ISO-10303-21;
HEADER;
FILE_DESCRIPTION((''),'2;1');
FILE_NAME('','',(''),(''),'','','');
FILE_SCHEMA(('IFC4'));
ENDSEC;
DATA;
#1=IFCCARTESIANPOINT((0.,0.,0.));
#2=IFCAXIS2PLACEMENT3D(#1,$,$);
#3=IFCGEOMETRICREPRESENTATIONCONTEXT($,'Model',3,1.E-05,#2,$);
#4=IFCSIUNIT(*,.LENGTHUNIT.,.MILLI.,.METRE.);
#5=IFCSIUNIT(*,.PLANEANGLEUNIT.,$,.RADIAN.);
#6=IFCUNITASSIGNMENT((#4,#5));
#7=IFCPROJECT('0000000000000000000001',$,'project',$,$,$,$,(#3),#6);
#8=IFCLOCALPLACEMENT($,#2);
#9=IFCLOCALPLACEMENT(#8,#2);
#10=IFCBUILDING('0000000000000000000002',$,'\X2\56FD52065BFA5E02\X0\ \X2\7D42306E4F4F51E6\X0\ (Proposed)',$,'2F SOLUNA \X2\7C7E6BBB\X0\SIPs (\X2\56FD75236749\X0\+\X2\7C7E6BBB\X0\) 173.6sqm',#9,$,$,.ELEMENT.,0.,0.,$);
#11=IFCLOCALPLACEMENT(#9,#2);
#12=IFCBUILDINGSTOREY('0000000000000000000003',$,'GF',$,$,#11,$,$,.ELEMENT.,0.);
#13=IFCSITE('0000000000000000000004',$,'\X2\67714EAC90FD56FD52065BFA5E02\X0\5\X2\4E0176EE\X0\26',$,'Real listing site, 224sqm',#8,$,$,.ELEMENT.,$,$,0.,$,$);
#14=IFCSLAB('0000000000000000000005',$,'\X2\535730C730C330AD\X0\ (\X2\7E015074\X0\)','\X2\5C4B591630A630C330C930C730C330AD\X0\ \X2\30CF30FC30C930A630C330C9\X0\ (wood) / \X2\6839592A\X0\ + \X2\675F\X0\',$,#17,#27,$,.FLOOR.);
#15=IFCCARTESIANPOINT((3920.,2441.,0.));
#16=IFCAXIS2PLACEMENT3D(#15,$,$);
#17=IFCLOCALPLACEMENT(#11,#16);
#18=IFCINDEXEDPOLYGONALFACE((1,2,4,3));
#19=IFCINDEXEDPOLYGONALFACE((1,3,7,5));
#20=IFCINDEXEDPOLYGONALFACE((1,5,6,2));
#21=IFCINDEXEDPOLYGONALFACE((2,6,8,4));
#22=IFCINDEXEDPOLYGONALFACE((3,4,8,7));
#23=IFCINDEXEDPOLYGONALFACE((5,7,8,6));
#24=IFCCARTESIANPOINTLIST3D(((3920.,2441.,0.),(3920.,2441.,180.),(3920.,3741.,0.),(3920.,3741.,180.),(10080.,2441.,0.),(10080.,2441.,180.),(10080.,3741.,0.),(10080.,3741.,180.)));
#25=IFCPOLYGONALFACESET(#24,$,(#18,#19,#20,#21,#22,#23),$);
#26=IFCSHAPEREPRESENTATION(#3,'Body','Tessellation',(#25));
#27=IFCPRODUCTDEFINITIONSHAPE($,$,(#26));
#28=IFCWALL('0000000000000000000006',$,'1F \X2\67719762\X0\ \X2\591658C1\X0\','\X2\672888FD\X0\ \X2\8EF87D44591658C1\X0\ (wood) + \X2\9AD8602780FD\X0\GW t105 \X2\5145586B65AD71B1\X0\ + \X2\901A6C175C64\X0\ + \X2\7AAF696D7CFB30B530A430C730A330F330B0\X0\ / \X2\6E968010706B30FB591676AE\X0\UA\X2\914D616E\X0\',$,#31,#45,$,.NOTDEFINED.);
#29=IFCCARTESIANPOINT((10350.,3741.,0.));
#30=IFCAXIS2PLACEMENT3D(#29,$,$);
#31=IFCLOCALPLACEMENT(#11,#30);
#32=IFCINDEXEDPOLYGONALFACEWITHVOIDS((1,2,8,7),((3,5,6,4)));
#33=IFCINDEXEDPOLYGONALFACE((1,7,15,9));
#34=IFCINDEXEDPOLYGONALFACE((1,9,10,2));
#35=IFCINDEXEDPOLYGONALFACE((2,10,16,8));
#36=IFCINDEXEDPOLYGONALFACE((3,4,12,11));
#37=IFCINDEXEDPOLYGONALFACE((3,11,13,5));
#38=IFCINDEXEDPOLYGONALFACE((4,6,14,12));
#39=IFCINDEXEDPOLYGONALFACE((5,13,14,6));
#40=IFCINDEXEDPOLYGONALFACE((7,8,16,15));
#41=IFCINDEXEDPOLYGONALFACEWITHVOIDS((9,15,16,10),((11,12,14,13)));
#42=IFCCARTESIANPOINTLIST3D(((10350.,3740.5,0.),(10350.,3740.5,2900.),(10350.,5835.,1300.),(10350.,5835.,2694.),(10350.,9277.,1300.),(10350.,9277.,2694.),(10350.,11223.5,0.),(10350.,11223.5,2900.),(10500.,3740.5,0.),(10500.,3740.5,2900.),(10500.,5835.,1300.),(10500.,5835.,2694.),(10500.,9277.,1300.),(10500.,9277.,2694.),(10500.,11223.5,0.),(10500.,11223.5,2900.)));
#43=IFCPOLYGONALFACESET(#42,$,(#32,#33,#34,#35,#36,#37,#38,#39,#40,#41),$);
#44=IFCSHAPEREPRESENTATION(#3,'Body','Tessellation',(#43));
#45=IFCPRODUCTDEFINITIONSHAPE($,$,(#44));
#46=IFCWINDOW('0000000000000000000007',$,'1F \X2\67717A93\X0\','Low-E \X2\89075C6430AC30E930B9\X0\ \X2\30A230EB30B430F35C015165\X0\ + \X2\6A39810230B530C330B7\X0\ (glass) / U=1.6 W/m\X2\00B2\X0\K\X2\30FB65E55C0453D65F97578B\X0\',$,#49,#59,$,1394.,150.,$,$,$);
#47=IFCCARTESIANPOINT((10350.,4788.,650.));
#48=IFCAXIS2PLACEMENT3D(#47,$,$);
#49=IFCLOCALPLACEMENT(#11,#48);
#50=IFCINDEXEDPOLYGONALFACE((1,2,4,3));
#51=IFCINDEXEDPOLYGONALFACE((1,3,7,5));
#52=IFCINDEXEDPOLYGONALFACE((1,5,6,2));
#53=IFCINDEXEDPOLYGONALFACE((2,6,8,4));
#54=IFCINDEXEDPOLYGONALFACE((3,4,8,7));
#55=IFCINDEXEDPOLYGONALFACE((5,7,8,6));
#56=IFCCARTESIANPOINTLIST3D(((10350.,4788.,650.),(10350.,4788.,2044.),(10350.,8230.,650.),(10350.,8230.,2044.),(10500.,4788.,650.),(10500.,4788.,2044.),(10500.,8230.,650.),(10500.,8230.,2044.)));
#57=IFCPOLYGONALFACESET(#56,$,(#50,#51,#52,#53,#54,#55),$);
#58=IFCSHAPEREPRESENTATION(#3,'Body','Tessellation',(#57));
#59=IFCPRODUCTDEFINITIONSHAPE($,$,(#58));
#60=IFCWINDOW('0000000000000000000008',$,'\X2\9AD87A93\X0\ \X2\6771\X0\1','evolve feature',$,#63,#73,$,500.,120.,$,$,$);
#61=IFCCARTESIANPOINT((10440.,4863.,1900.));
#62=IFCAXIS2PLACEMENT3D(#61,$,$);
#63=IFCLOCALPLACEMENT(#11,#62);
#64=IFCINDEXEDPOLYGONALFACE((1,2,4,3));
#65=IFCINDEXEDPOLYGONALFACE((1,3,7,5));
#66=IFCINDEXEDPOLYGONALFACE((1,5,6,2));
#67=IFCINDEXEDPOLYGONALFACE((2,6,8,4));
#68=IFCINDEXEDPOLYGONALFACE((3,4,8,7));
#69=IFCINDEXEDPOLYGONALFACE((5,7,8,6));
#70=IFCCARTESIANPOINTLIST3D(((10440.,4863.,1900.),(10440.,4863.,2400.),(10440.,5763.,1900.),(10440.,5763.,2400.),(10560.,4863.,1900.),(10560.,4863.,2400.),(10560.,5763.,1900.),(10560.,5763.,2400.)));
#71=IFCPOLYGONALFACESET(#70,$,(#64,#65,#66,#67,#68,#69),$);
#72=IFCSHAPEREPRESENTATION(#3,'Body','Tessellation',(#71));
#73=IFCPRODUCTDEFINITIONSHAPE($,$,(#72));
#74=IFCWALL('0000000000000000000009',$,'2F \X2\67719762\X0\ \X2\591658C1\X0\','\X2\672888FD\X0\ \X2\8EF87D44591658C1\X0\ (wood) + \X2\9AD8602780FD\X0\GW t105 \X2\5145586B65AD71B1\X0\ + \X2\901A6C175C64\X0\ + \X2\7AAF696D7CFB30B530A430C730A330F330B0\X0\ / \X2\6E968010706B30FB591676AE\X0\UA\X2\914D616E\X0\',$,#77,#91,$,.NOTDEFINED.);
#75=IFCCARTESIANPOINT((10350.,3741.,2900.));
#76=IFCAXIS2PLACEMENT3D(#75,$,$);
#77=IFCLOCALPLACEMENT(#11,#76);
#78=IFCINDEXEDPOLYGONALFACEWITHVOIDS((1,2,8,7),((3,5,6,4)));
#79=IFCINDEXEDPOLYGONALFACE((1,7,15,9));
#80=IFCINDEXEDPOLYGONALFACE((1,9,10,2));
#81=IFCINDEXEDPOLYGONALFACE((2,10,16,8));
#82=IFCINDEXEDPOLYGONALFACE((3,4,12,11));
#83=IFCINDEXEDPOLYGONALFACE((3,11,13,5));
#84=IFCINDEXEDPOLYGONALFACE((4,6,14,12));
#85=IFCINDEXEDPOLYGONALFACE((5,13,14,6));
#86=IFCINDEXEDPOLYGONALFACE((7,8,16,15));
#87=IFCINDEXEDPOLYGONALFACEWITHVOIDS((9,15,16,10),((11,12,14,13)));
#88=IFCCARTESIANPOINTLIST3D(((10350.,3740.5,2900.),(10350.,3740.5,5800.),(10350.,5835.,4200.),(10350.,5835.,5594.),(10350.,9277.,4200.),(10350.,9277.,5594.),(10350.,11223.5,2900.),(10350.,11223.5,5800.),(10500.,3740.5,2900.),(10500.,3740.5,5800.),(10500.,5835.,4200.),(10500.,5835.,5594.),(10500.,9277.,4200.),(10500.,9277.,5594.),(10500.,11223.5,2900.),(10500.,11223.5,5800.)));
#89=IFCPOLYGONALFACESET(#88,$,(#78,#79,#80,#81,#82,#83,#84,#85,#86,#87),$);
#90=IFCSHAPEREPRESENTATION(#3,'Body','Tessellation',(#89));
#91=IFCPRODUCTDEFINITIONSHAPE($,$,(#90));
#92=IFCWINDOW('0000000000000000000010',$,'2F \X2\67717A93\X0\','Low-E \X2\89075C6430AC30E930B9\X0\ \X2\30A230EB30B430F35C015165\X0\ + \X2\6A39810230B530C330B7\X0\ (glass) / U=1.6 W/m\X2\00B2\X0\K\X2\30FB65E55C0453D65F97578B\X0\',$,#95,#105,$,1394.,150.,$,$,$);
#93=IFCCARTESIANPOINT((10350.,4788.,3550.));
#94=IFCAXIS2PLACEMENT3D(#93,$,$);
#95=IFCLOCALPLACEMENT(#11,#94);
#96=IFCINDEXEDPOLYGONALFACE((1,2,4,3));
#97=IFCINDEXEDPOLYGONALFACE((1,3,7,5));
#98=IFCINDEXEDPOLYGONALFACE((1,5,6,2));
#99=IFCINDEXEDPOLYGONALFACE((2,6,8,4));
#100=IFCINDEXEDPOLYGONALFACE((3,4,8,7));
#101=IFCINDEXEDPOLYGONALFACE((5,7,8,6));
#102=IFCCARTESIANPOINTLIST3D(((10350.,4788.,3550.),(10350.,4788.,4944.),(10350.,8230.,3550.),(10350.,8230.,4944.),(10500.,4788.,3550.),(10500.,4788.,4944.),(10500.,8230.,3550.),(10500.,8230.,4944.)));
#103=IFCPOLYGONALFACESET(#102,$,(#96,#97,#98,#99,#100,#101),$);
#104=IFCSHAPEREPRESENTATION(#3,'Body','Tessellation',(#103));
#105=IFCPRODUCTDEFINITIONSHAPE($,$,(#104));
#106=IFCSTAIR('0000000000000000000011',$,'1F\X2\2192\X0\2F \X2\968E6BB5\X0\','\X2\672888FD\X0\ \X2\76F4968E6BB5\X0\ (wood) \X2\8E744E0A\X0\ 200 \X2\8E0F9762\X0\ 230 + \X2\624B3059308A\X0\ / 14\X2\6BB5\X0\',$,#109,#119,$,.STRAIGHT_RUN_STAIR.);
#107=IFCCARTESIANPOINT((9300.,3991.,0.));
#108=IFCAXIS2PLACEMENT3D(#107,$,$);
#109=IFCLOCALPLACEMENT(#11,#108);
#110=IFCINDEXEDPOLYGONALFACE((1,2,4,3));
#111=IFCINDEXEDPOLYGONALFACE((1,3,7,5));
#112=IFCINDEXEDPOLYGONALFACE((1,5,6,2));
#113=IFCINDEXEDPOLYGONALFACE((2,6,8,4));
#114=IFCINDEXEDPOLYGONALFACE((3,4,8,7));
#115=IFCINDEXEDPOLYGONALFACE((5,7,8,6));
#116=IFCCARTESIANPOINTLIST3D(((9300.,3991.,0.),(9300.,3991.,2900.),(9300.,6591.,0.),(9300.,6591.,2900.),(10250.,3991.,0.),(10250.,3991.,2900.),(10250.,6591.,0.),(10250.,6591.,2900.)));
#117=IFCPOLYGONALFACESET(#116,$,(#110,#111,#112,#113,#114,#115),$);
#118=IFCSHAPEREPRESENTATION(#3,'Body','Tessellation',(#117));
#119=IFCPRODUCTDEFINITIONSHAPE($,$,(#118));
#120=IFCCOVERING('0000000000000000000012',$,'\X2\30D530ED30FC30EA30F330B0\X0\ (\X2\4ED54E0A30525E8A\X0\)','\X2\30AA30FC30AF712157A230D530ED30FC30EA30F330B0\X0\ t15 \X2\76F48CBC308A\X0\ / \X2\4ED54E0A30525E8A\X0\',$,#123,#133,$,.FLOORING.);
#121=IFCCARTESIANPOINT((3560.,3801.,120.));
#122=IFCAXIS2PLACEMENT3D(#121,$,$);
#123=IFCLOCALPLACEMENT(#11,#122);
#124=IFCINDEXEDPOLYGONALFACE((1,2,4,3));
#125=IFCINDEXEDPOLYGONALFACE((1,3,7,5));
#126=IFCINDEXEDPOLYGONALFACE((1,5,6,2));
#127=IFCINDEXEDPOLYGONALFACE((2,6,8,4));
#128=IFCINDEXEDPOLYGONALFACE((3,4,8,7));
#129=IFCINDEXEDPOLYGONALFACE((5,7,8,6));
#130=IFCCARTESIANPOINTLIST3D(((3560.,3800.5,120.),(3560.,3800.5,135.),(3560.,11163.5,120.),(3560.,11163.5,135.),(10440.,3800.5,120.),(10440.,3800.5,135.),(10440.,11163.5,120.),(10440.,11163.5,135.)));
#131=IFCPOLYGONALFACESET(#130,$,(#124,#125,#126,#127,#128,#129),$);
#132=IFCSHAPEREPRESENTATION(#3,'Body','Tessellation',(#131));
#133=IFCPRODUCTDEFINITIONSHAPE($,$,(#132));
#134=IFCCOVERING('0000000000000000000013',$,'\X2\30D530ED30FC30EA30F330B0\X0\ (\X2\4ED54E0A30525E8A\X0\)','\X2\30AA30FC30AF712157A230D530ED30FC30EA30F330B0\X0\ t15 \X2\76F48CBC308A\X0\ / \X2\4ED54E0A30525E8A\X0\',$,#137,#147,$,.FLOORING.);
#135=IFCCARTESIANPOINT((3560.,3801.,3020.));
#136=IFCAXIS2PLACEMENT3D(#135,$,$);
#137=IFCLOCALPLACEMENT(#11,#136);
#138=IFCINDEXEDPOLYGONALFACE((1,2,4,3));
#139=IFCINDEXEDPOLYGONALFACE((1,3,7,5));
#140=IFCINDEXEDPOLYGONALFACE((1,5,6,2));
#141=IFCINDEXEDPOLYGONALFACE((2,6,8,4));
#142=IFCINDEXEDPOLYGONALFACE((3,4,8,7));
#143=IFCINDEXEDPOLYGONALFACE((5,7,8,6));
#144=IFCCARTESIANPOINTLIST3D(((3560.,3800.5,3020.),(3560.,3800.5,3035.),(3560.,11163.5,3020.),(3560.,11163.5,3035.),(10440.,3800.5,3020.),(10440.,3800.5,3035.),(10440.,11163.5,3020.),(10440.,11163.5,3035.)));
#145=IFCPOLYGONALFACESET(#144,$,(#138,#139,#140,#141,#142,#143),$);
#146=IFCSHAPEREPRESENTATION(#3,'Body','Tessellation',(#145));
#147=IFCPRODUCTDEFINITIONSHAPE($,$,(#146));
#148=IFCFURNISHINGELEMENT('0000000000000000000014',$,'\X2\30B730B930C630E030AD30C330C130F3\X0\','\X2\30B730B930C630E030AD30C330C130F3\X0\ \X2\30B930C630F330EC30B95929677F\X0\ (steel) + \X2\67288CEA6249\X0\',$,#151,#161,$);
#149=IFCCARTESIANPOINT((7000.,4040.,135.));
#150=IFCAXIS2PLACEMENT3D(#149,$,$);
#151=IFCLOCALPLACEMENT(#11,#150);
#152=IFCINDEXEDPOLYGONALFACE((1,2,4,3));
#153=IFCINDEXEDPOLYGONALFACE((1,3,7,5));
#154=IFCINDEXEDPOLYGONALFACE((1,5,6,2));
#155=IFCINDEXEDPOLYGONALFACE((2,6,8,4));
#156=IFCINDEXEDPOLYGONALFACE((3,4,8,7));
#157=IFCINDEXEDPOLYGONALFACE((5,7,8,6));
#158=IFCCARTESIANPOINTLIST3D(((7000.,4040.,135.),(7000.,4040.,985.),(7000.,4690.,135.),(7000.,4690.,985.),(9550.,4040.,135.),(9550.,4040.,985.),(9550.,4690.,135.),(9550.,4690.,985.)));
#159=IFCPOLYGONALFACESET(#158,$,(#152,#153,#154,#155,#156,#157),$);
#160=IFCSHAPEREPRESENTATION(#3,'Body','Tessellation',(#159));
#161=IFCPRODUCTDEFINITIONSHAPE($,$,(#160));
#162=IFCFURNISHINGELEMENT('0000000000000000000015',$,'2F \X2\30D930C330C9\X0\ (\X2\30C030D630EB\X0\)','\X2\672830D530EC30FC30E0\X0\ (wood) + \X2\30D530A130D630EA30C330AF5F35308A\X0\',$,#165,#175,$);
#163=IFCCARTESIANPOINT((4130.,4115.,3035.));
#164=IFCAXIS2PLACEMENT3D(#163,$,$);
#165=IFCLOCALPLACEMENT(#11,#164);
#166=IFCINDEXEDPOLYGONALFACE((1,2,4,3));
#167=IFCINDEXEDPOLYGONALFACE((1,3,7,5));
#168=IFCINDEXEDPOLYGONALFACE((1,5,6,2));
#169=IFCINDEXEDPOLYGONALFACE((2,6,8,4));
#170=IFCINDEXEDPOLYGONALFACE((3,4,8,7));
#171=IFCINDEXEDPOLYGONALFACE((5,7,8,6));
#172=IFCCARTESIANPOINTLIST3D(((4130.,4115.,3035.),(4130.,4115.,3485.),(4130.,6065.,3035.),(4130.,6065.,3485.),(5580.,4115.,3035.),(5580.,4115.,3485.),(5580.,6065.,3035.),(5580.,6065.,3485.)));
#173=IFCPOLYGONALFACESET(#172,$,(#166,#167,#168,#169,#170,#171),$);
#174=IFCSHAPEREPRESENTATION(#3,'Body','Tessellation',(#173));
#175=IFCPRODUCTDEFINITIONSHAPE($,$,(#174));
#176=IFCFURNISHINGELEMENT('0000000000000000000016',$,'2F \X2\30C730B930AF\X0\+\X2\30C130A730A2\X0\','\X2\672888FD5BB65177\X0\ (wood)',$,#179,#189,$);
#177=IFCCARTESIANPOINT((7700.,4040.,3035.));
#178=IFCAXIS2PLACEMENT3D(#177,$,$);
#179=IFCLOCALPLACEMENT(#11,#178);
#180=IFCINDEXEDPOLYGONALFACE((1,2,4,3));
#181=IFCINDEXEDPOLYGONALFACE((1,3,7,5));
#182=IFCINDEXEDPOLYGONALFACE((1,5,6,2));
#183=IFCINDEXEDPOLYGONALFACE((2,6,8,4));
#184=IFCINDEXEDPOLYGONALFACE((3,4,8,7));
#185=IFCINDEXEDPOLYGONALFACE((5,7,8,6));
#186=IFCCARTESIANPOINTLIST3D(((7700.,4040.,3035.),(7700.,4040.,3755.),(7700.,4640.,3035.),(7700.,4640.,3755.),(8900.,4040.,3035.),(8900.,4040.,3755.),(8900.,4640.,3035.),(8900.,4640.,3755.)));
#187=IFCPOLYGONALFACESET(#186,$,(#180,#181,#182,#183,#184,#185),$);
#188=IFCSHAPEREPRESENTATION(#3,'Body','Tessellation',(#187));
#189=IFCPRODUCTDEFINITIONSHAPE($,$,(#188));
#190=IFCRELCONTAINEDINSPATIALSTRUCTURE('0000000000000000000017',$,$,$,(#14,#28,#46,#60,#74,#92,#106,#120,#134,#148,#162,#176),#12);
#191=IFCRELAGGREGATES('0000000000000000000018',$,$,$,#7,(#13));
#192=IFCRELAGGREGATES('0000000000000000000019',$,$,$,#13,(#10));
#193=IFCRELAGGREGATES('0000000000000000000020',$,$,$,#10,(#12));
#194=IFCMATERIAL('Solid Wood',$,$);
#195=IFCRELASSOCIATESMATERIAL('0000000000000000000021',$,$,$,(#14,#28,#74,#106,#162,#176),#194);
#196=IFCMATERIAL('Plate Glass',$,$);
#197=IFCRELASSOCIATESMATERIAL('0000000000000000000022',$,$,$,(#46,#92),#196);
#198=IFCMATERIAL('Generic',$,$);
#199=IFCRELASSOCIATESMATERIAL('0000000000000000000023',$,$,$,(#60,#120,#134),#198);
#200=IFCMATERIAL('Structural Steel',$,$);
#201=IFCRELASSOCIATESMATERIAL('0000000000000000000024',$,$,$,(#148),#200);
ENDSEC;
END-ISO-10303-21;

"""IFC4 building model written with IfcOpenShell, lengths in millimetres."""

from ifc_helpers import new_model, si_unit, frame, frame_2d, origin, place, context, project, spatial, rectangle, extrude, material, element, fill, save


model = new_model("IFC4")

# Units and contexts
model_context = context("Model", 3, precision=1e-05, world=origin())
ifc_project = project(units=[si_unit("LENGTHUNIT", "METRE", prefix="MILLI"), si_unit("PLANEANGLEUNIT", "RADIAN")], contexts=[model_context])

# Site, building, storey
site_placement = place(None, origin())
site = spatial("IfcSite", under=ifc_project, at=site_placement, Name="東京都国分寺市5丁目26", ObjectType="Real listing site, 224sqm", CompositionType="ELEMENT", RefElevation=0.0)
building_placement = place(site_placement, origin())
building = spatial("IfcBuilding", under=site, at=building_placement, Name="国分寺市 終の住処 (Proposed)", ObjectType="2F SOLUNA 籾殻SIPs (国産杉+籾殻) 173.6sqm", CompositionType="ELEMENT", ElevationOfRefHeight=0.0, ElevationOfTerrain=0.0)
storey_placement = place(building_placement, origin())
storey = spatial("IfcBuildingStorey", under=building, at=storey_placement, Name="GF", CompositionType="ELEMENT", Elevation=0.0)

# Slab
ifc_material_1 = material(Name="Solid Wood")
slab_placement = place(storey_placement, frame((3920.0, 2441.0, 0.0)))
element("IfcSlab", 1, at=slab_placement, inside=storey, material=ifc_material_1, Name="南デッキ (縁側)", Description="屋外ウッドデッキ ハードウッド (wood) / 根太 + 束", PredefinedType="FLOOR", context=model_context, shape_type="SweptSolid", body=[
    extrude(rectangle(XDim=6160.0, YDim=1300.0, at=frame_2d((3080.0, 650.0))), frame((3920.0, 2441.0, 0.0)), (0.0, 0.0, 1.0), 180.0),
])

# Wall, openings, windows
wall_1_placement = place(storey_placement, frame((10350.0, 3741.0, 0.0)))
wall_1 = element("IfcWall", 2, at=wall_1_placement, inside=storey, material=ifc_material_1, Name="1F 東面 外壁", Description="木製 軸組外壁 (wood) + 高性能GW t105 充填断熱 + 通気層 + 窯業系サイディング / 準耐火・外皮UA配慮", PredefinedType="NOTDEFINED", context=model_context, shape_type="SweptSolid", body=[
    extrude(rectangle(XDim=150.0, YDim=7483.0, at=frame_2d((75.0, 3741.0))), frame((10350.0, 3741.0, 0.0)), (0.0, 0.0, 1.0), 2900.0),
])
opening_1_placement = place(storey_placement, frame((10350.0, 4788.0, 650.0)))
opening_1 = element("IfcOpeningElement", 3, at=opening_1_placement, cuts=wall_1, PredefinedType="NOTDEFINED", context=model_context, shape_type="SweptSolid", body=[
    extrude(rectangle(XDim=150.0, YDim=3442.0, at=frame_2d((75.0, 1721.0))), frame((10350.0, 4788.0, 650.0)), (0.0, 0.0, 1.0), 1394.0),
])
opening_2_placement = place(storey_placement, frame((10440.0, 4863.0, 1900.0)))
opening_2 = element("IfcOpeningElement", 4, at=opening_2_placement, cuts=wall_1, PredefinedType="NOTDEFINED", context=model_context, shape_type="SweptSolid", body=[
    extrude(rectangle(XDim=120.0, YDim=900.0, at=frame_2d((60.0, 450.0))), frame((10440.0, 4863.0, 1900.0)), (0.0, 0.0, 1.0), 500.0),
])
ifc_material_2 = material(Name="Plate Glass")
window_1_placement = place(storey_placement, frame((10350.0, 4788.0, 650.0)))
window_1 = element("IfcWindow", 5, at=window_1_placement, inside=storey, material=ifc_material_2, Name="1F 東窓", Description="Low-E 複層ガラス アルゴン封入 + 樹脂サッシ (glass) / U=1.6 W/m²K・日射取得型", OverallHeight=1394.0, OverallWidth=150.0, context=model_context, shape_type="SweptSolid", body=[
    extrude(rectangle(XDim=150.0, YDim=3442.0, at=frame_2d((75.0, 1721.0))), frame((10350.0, 4788.0, 650.0)), (0.0, 0.0, 1.0), 1394.0),
])
fill(opening_1, window_1)
ifc_material_3 = material(Name="Generic")
window_2_placement = place(storey_placement, frame((10440.0, 4863.0, 1900.0)))
window_2 = element("IfcWindow", 6, at=window_2_placement, inside=storey, material=ifc_material_3, Name="高窓 東1", Description="evolve feature", OverallHeight=500.0, OverallWidth=120.0, context=model_context, shape_type="SweptSolid", body=[
    extrude(rectangle(XDim=120.0, YDim=900.0, at=frame_2d((60.0, 450.0))), frame((10440.0, 4863.0, 1900.0)), (0.0, 0.0, 1.0), 500.0),
])
fill(opening_2, window_2)

# Wall, opening, window
wall_2_placement = place(storey_placement, frame((10350.0, 3741.0, 2900.0)))
wall_2 = element("IfcWall", 7, at=wall_2_placement, inside=storey, material=ifc_material_1, Name="2F 東面 外壁", Description="木製 軸組外壁 (wood) + 高性能GW t105 充填断熱 + 通気層 + 窯業系サイディング / 準耐火・外皮UA配慮", PredefinedType="NOTDEFINED", context=model_context, shape_type="SweptSolid", body=[
    extrude(rectangle(XDim=150.0, YDim=7483.0, at=frame_2d((75.0, 3741.0))), frame((10350.0, 3741.0, 2900.0)), (0.0, 0.0, 1.0), 2900.0),
])
opening_3_placement = place(storey_placement, frame((10350.0, 4788.0, 3550.0)))
opening_3 = element("IfcOpeningElement", 8, at=opening_3_placement, cuts=wall_2, PredefinedType="NOTDEFINED", context=model_context, shape_type="SweptSolid", body=[
    extrude(rectangle(XDim=150.0, YDim=3442.0, at=frame_2d((75.0, 1721.0))), frame((10350.0, 4788.0, 3550.0)), (0.0, 0.0, 1.0), 1394.0),
])
window_3_placement = place(storey_placement, frame((10350.0, 4788.0, 3550.0)))
window_3 = element("IfcWindow", 9, at=window_3_placement, inside=storey, material=ifc_material_2, Name="2F 東窓", Description="Low-E 複層ガラス アルゴン封入 + 樹脂サッシ (glass) / U=1.6 W/m²K・日射取得型", OverallHeight=1394.0, OverallWidth=150.0, context=model_context, shape_type="SweptSolid", body=[
    extrude(rectangle(XDim=150.0, YDim=3442.0, at=frame_2d((75.0, 1721.0))), frame((10350.0, 4788.0, 3550.0)), (0.0, 0.0, 1.0), 1394.0),
])
fill(opening_3, window_3)

# Stair
stair_placement = place(storey_placement, frame((9300.0, 3991.0, 0.0)))
element("IfcStair", 10, at=stair_placement, inside=storey, material=ifc_material_1, Name="1F→2F 階段", Description="木製 直階段 (wood) 蹴上 200 踏面 230 + 手すり / 14段", PredefinedType="STRAIGHT_RUN_STAIR", context=model_context, shape_type="SweptSolid", body=[
    extrude(rectangle(XDim=950.0, YDim=2600.0, at=frame_2d((475.0, 1300.0))), frame((9300.0, 3991.0, 0.0)), (0.0, 0.0, 1.0), 2900.0),
])

# Coverings
covering_1_placement = place(storey_placement, frame((3560.0, 3801.0, 120.0)))
element("IfcCovering", 11, at=covering_1_placement, inside=storey, material=ifc_material_3, Name="フローリング (仕上げ床)", Description="オーク無垢フローリング t15 直貼り / 仕上げ床", PredefinedType="FLOORING", context=model_context, shape_type="SweptSolid", body=[
    extrude(rectangle(XDim=6880.0, YDim=7363.0, at=frame_2d((3440.0, 3681.0))), frame((3560.0, 3801.0, 120.0)), (0.0, 0.0, 1.0), 15.0),
])
covering_2_placement = place(storey_placement, frame((3560.0, 3801.0, 3020.0)))
element("IfcCovering", 12, at=covering_2_placement, inside=storey, material=ifc_material_3, Name="フローリング (仕上げ床)", Description="オーク無垢フローリング t15 直貼り / 仕上げ床", PredefinedType="FLOORING", context=model_context, shape_type="SweptSolid", body=[
    extrude(rectangle(XDim=6880.0, YDim=7363.0, at=frame_2d((3440.0, 3681.0))), frame((3560.0, 3801.0, 3020.0)), (0.0, 0.0, 1.0), 15.0),
])

# Furnishing elements
ifc_material_4 = material(Name="Structural Steel")
furnishing_1_placement = place(storey_placement, frame((7000.0, 4040.0, 135.0)))
element("IfcFurnishingElement", 13, at=furnishing_1_placement, inside=storey, material=ifc_material_4, Name="システムキッチン", Description="システムキッチン ステンレス天板 (steel) + 木質扉", context=model_context, shape_type="SweptSolid", body=[
    extrude(rectangle(XDim=2550.0, YDim=650.0, at=frame_2d((1275.0, 325.0))), frame((7000.0, 4040.0, 135.0)), (0.0, 0.0, 1.0), 850.0),
])
furnishing_2_placement = place(storey_placement, frame((4130.0, 4115.0, 3035.0)))
element("IfcFurnishingElement", 14, at=furnishing_2_placement, inside=storey, material=ifc_material_1, Name="2F ベッド (ダブル)", Description="木フレーム (wood) + ファブリック張り", context=model_context, shape_type="SweptSolid", body=[
    extrude(rectangle(XDim=1450.0, YDim=1950.0, at=frame_2d((725.0, 975.0))), frame((4130.0, 4115.0, 3035.0)), (0.0, 0.0, 1.0), 450.0),
])
furnishing_3_placement = place(storey_placement, frame((7700.0, 4040.0, 3035.0)))
element("IfcFurnishingElement", 15, at=furnishing_3_placement, inside=storey, material=ifc_material_1, Name="2F デスク+チェア", Description="木製家具 (wood)", context=model_context, shape_type="SweptSolid", body=[
    extrude(rectangle(XDim=1200.0, YDim=600.0, at=frame_2d((600.0, 300.0))), frame((7700.0, 4040.0, 3035.0)), (0.0, 0.0, 1.0), 720.0),
])

save(model, "model.ifc")
